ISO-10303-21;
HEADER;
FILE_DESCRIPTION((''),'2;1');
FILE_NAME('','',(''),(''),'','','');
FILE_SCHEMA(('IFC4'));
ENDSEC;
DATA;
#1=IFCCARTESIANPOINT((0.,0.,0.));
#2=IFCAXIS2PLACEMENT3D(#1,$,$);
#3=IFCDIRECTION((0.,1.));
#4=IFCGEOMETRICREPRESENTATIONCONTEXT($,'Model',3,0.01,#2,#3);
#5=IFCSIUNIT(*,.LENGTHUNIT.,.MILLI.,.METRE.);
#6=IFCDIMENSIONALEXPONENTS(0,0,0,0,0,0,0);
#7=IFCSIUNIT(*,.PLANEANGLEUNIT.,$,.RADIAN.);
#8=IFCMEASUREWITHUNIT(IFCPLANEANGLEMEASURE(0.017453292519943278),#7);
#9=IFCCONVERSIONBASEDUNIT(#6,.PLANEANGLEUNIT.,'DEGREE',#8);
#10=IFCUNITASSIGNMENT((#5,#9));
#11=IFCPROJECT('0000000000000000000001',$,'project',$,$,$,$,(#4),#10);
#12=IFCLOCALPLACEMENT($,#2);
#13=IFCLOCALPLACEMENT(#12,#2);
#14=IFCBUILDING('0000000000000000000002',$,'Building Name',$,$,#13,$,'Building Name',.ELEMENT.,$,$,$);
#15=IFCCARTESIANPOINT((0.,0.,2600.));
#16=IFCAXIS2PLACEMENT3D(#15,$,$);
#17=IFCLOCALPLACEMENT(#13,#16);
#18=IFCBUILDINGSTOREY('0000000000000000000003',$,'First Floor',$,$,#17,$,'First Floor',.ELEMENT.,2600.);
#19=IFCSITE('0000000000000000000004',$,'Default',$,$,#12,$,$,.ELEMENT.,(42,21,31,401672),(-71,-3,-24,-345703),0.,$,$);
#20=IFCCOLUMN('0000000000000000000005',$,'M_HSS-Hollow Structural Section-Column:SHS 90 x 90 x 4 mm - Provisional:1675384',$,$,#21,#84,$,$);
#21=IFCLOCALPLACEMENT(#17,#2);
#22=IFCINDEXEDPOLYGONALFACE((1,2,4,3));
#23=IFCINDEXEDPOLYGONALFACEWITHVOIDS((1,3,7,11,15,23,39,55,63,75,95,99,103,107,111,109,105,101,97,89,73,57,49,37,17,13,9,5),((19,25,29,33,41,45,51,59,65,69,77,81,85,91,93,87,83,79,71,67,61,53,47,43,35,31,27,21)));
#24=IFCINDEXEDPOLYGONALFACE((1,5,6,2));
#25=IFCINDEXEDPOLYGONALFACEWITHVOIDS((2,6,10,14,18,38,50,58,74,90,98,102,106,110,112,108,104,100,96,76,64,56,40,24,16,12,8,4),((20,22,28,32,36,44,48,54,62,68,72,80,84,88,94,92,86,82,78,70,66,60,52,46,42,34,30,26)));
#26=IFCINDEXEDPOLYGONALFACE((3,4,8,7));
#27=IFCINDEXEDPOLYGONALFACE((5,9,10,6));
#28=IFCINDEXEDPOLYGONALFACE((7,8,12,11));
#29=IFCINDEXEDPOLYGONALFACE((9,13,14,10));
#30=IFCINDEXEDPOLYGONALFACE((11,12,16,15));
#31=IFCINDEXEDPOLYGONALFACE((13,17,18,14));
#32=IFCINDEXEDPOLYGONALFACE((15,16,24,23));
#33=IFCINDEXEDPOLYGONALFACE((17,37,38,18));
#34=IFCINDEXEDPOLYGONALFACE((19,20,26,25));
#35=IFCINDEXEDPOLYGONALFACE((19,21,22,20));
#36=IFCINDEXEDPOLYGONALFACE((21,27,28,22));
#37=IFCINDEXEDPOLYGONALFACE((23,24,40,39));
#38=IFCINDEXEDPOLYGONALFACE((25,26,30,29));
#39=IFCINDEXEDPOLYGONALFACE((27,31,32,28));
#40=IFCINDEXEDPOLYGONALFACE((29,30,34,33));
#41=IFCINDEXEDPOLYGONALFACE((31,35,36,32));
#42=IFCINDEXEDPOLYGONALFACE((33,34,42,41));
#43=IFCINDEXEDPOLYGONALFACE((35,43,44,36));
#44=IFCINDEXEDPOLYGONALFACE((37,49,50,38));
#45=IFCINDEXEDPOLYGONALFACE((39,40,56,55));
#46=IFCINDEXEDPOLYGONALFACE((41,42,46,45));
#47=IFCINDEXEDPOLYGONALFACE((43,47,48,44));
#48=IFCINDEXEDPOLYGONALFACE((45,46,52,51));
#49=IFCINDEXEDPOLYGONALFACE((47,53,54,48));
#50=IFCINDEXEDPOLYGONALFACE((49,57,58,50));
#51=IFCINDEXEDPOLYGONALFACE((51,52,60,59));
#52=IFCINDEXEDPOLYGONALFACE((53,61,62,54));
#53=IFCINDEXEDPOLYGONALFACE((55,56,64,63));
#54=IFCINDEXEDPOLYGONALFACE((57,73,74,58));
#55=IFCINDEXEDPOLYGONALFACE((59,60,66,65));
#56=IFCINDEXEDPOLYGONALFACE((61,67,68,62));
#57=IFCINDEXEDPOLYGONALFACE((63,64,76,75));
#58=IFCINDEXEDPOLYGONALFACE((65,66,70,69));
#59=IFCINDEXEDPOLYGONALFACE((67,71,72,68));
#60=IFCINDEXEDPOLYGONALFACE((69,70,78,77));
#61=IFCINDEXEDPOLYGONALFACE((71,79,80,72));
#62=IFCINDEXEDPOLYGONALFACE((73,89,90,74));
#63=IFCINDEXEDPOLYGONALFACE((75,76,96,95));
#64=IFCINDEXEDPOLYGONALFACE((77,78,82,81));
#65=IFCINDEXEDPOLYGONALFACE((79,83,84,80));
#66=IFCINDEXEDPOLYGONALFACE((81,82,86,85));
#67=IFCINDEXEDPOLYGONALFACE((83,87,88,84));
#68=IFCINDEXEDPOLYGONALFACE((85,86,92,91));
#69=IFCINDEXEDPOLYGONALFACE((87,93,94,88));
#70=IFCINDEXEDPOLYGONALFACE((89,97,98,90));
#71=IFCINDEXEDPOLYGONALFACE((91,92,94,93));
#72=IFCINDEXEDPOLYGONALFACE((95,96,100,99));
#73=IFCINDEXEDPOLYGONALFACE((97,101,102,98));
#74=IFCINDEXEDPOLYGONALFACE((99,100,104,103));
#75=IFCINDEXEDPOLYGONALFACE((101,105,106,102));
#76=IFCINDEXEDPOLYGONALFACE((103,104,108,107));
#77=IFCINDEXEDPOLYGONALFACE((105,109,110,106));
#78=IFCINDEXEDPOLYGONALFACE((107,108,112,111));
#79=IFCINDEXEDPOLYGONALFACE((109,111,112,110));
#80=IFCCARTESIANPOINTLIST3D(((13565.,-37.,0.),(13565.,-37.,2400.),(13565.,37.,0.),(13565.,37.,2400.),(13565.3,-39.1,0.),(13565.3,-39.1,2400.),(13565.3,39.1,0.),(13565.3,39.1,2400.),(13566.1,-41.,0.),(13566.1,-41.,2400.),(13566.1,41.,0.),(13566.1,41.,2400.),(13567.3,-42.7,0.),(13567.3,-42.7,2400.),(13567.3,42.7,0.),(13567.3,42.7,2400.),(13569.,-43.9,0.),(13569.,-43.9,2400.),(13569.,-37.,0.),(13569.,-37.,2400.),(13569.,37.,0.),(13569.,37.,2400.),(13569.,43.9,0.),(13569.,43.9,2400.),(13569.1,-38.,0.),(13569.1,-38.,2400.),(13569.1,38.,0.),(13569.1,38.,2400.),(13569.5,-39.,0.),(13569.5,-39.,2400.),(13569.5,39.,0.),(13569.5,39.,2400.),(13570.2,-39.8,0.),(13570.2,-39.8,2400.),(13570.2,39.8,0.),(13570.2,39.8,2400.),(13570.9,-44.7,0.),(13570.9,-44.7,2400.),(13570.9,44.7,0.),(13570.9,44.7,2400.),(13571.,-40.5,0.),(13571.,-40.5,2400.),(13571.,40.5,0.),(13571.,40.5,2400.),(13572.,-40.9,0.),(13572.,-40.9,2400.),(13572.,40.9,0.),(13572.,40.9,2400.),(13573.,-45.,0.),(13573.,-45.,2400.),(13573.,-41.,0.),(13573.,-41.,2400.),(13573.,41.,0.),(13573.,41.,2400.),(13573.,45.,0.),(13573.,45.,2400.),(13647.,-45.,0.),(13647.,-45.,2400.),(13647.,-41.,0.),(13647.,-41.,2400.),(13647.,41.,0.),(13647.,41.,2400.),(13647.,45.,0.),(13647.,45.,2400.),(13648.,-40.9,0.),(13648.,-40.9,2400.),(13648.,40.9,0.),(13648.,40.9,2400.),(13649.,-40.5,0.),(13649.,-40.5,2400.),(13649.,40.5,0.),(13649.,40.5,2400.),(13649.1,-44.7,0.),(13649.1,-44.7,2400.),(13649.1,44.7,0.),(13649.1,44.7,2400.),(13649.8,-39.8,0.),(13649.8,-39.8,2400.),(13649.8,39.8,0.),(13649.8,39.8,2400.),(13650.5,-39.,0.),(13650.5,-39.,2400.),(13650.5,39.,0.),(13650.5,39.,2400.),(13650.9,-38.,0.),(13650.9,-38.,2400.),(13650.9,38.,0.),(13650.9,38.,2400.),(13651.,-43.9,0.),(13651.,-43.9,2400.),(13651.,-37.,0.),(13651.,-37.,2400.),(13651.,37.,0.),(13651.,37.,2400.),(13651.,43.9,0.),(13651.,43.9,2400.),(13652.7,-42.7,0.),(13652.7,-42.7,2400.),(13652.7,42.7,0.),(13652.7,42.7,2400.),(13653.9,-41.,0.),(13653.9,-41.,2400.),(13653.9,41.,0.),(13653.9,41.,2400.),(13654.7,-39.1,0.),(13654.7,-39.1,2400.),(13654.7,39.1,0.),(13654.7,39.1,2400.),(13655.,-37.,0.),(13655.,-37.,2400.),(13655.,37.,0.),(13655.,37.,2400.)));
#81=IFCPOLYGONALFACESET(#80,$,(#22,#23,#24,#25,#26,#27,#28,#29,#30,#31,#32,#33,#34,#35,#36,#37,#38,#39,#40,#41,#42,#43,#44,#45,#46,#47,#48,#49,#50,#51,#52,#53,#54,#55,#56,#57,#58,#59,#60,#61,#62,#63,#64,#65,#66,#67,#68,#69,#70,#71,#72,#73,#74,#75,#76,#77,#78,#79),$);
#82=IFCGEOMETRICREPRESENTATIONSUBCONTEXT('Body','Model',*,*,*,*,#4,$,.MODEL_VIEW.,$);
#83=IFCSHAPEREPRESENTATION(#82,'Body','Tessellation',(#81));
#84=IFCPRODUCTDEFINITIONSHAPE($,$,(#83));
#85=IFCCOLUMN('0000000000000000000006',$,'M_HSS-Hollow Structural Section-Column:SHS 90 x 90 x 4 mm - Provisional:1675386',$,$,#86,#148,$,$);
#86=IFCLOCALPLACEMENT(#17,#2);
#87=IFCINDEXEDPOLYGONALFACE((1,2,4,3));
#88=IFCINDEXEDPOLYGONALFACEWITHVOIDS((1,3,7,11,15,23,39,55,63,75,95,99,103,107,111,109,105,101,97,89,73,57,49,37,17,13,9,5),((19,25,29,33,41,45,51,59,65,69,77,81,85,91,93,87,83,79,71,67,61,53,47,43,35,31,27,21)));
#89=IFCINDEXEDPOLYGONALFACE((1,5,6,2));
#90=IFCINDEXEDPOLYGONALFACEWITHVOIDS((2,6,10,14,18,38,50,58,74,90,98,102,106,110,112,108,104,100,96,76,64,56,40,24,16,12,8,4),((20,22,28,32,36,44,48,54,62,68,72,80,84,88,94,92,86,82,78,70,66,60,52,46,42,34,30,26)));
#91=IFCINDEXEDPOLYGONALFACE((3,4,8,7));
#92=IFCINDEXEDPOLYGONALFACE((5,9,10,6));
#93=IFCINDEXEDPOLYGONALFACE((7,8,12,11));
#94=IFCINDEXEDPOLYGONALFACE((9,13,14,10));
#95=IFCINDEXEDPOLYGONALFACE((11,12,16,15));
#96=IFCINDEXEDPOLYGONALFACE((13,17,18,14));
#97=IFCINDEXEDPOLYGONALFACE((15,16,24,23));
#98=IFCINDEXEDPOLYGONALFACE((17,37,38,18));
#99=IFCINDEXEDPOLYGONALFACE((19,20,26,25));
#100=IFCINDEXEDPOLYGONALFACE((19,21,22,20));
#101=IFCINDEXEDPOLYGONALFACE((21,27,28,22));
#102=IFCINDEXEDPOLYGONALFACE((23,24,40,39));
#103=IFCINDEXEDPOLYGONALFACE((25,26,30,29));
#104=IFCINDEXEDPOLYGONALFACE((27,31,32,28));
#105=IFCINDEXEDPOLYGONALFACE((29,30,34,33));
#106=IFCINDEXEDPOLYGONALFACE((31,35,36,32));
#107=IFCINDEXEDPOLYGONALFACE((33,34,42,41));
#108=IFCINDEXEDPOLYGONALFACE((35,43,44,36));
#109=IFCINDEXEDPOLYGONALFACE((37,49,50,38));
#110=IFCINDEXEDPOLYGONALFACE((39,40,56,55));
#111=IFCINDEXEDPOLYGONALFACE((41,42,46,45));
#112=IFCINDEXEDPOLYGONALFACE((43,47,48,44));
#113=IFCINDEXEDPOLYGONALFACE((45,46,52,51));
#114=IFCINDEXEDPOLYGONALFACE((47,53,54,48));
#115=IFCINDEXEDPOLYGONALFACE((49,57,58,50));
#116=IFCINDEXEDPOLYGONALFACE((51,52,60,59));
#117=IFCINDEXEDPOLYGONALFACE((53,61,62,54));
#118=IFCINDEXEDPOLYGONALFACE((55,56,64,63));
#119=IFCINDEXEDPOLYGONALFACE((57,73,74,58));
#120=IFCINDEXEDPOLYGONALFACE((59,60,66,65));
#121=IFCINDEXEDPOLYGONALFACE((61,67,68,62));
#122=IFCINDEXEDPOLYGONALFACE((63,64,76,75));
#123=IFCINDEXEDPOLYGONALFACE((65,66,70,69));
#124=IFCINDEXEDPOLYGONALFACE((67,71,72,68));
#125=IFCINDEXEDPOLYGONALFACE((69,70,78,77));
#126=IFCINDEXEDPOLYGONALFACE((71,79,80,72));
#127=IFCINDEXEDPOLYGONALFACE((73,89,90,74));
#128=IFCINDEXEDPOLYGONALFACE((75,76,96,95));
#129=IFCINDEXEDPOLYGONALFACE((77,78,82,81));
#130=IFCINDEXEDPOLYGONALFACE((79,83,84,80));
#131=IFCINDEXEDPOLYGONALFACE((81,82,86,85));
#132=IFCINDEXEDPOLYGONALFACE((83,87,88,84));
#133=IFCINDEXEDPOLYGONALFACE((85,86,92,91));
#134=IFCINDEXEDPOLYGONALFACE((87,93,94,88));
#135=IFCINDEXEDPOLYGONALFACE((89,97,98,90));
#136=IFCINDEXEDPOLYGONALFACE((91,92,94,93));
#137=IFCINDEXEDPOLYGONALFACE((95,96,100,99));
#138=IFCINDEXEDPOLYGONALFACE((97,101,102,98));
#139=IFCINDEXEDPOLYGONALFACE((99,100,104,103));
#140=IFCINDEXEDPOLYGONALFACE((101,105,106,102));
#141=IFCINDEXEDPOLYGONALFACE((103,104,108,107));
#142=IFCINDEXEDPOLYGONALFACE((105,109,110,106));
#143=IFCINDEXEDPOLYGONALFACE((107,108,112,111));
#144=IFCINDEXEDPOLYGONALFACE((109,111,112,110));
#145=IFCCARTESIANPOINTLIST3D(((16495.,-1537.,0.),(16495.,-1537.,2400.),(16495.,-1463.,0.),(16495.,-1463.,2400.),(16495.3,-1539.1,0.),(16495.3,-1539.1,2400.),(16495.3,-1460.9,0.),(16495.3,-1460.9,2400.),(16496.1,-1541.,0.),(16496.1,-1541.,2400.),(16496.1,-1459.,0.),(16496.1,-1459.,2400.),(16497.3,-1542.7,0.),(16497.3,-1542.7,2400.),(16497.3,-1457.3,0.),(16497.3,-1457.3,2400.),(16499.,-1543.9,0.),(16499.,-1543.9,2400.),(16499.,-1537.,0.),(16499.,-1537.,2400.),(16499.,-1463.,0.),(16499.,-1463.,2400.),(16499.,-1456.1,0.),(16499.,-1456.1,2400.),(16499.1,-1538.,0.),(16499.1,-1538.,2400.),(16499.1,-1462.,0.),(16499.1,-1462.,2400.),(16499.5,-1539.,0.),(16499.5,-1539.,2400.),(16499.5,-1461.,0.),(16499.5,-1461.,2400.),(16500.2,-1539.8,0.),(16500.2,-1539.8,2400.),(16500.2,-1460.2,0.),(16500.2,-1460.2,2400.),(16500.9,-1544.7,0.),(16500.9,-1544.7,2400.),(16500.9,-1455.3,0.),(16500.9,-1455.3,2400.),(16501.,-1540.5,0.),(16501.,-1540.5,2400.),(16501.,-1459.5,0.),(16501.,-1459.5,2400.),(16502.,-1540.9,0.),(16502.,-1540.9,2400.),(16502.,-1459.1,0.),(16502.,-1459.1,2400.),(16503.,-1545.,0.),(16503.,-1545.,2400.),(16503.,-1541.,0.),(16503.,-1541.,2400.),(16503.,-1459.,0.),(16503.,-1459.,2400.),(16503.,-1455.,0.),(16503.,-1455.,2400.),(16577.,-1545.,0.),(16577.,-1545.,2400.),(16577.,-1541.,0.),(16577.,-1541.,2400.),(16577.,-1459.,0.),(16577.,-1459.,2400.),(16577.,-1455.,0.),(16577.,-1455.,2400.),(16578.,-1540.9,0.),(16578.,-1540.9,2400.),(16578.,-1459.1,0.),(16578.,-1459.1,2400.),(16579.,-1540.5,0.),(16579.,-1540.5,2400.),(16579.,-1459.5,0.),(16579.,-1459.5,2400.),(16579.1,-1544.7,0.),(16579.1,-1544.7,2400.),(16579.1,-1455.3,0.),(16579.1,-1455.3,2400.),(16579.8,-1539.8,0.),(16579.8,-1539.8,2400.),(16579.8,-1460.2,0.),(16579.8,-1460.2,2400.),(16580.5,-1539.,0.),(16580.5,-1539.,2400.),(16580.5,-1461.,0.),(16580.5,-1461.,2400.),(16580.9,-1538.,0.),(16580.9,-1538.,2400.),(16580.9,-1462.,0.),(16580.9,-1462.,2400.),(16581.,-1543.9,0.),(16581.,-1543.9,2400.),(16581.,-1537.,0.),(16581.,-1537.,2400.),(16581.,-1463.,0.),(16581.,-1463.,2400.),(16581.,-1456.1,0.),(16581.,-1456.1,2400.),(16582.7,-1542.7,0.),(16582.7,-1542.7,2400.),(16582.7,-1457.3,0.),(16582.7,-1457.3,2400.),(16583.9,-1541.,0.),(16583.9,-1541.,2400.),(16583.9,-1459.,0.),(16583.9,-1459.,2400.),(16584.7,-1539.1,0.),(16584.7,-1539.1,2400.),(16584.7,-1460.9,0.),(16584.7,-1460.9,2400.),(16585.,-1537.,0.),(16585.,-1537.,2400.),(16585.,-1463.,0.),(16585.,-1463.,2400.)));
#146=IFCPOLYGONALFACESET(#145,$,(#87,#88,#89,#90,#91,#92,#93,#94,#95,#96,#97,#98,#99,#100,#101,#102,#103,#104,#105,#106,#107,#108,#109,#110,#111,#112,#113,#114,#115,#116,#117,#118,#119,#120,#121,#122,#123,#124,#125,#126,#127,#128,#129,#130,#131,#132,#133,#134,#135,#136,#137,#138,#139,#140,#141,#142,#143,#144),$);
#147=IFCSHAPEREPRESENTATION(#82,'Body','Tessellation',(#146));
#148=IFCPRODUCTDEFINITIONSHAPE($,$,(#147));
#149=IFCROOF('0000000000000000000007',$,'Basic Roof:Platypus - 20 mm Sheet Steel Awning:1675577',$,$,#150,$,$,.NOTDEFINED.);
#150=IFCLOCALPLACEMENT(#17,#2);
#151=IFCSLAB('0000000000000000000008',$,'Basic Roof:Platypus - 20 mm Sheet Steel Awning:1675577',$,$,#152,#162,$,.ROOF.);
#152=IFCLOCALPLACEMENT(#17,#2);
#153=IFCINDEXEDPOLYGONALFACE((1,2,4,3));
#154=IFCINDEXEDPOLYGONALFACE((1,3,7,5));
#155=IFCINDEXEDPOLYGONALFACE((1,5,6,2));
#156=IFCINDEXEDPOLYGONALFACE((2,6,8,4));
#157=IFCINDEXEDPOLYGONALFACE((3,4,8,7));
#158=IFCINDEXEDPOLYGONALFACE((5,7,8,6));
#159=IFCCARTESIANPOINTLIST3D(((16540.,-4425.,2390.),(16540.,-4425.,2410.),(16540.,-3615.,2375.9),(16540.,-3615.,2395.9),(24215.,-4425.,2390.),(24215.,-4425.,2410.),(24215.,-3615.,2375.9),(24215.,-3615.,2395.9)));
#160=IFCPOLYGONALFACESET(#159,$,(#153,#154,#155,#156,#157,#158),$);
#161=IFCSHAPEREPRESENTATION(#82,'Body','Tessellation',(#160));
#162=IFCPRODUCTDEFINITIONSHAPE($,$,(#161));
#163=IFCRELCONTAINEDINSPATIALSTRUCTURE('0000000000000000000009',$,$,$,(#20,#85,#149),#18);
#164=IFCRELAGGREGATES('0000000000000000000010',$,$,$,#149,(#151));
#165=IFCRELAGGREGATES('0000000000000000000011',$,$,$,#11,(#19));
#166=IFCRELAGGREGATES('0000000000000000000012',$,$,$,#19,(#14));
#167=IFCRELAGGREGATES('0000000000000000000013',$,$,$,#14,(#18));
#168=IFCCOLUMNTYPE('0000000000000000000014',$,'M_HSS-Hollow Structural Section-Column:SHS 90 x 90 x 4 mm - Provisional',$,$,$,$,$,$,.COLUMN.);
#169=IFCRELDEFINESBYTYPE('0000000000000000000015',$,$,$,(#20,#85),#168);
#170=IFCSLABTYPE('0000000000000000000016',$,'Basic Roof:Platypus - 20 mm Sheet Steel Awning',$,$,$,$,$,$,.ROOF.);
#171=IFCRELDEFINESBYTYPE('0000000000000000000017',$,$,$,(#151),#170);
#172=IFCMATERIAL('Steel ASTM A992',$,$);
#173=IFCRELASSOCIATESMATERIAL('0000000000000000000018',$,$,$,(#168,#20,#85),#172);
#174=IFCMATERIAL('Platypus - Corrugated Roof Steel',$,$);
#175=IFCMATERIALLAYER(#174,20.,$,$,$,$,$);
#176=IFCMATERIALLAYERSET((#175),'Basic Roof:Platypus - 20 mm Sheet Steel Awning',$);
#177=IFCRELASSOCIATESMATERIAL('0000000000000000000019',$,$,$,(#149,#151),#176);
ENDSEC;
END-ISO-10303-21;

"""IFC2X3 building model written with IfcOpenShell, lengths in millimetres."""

from ifc_helpers import new_model, entity, si_unit, converted_unit, direction, frame, frame_2d, origin, place, context, subcontext, project, spatial, polyline, circle_curve, parameter, trimmed, segment, composite_curve, rectangle, outline, extrude, source, transform, mapped, material, layer, layer_set, type_object, type_shapes, element, aggregate, save


model = new_model("IFC2X3")

# Units and contexts
model_context = context("Model", 3, precision=0.01, world=origin(), true_north=direction((0.0, 1.0)))
body_context = subcontext(model_context, "Body", "Model", "MODEL_VIEW")
ifc_project = project(units=[si_unit("LENGTHUNIT", "METRE", prefix="MILLI"), converted_unit("PLANEANGLEUNIT", "DEGREE", entity("IfcPlaneAngleMeasure", 0.017453292519943278), si_unit("PLANEANGLEUNIT", "RADIAN"), dimensions=[0, 0, 0, 0, 0, 0, 0])], contexts=[model_context])

# Site, building, storey
site_placement = place(None, origin())
site = spatial("IfcSite", under=ifc_project, at=site_placement, Name="Default", CompositionType="ELEMENT", RefLatitude=(42, 21, 31, 401672), RefLongitude=(-71, -3, -24, -345703), RefElevation=0.0)
building_placement = place(site_placement, origin())
building = spatial("IfcBuilding", under=site, at=building_placement, Name="Building Name", LongName="Building Name", CompositionType="ELEMENT")
storey_placement = place(building_placement, frame((0.0, 0.0, 2600.0)))
storey = spatial("IfcBuildingStorey", under=building, at=storey_placement, Name="First Floor", LongName="First Floor", CompositionType="ELEMENT", Elevation=2600.0)

# Columns
ifc_material_1 = material(Name="Steel ASTM A992")
column_type = type_object("IfcColumnType", Name="M_HSS-Hollow Structural Section-Column:SHS 90 x 90 x 4 mm - Provisional", PredefinedType="COLUMN", material=ifc_material_1)
shared_shape_1 = source(origin(), body_context, "Body", "SweptSolid", [
    extrude(outline(composite_curve([segment(polyline([(-37.0, -45.0), (37.0, -45.0)]), True, "CONTINUOUS"), segment(trimmed(circle_curve(frame_2d((37.0, -37.0), x_axis=(-1.0, 0.0)), 8.0), [parameter(90.0)], [parameter(180.0)], True, "PARAMETER"), True, "CONTINUOUS"), segment(polyline([(45.0, -37.0), (45.0, 37.0)]), True, "CONTINUOUS"), segment(trimmed(circle_curve(frame_2d((37.0, 37.0), x_axis=(-1.0, 0.0)), 8.0), [parameter(180.0)], [parameter(270.0)], True, "PARAMETER"), True, "CONTINUOUS"), segment(polyline([(37.0, 45.0), (-37.0, 45.0)]), True, "CONTINUOUS"), segment(trimmed(circle_curve(frame_2d((-37.0, 37.0), x_axis=(-1.0, 0.0)), 8.0), [parameter(270.0)], [parameter(360.0)], True, "PARAMETER"), True, "CONTINUOUS"), segment(polyline([(-45.0, 37.0), (-45.0, -37.0)]), True, "CONTINUOUS"), segment(trimmed(circle_curve(frame_2d((-37.0, -37.0), x_axis=(-1.0, 0.0)), 8.0), [parameter(360.0)], [parameter(90.0)], True, "PARAMETER"), True, "CONTINUOUS")], self_intersect=False), holes=[composite_curve([segment(trimmed(circle_curve(frame_2d((-37.0, -37.0), x_axis=(-1.0, 0.0)), 4.0), [parameter(0.0)], [parameter(90.0)], True, "PARAMETER"), False, "CONTINUOUS"), segment(polyline([(-41.0, -37.0), (-41.0, 37.0)]), True, "CONTINUOUS"), segment(trimmed(circle_curve(frame_2d((-37.0, 37.0), x_axis=(-1.0, 0.0)), 4.0), [parameter(270.0)], [parameter(0.0)], True, "PARAMETER"), False, "CONTINUOUS"), segment(polyline([(-37.0, 41.0), (37.0, 41.0)]), True, "CONTINUOUS"), segment(trimmed(circle_curve(frame_2d((37.0, 37.0), x_axis=(-1.0, 0.0)), 4.0), [parameter(180.0)], [parameter(270.0)], True, "PARAMETER"), False, "CONTINUOUS"), segment(polyline([(41.0, 37.0), (41.0, -37.0)]), True, "CONTINUOUS"), segment(trimmed(circle_curve(frame_2d((37.0, -37.0), x_axis=(-1.0, 0.0)), 4.0), [parameter(90.0)], [parameter(180.0)], True, "PARAMETER"), False, "CONTINUOUS"), segment(polyline([(37.0, -41.0), (-37.0, -41.0)]), True, "CONTINUOUS")], self_intersect=False)]), frame((0.0, 0.0, 2600.0), z_axis=(0.0, 0.0, 1.0), x_axis=(-1.0, 0.0, 0.0)), (0.0, 0.0, 1.0), 2400.0),
])
type_shapes(column_type, [shared_shape_1])
for number, where, name in (
    (1, (13610.0, 0.0, -2600.0), "M_HSS-Hollow Structural Section-Column:SHS 90 x 90 x 4 mm - Provisional:1675384"),
    (2, (16540.0, -1500.0, -2600.0), "M_HSS-Hollow Structural Section-Column:SHS 90 x 90 x 4 mm - Provisional:1675386"),
):
    element("IfcColumn", number, at=place(storey_placement, frame(where)), inside=storey, type_object=column_type, material=ifc_material_1, Name=name, context=body_context, shape_type="MappedRepresentation", body=[
        mapped(shared_shape_1, transform((0.0, 0.0, 0.0), scale=1.0)),
    ])

# Roof, slab
ifc_material_2 = material(Name="Platypus - Corrugated Roof Steel")
ifc_layer_1 = layer(ifc_material_2, 20.0)
ifc_layer_set_1 = layer_set([ifc_layer_1], Name="Basic Roof:Platypus - 20 mm Sheet Steel Awning")
roof_placement = place(storey_placement, frame((16540.0, -4425.0, 2375.9)))
roof = element("IfcRoof", 3, at=roof_placement, inside=storey, material=ifc_layer_set_1, Name="Basic Roof:Platypus - 20 mm Sheet Steel Awning:1675577", ShapeType="NOTDEFINED")
slab_type = type_object("IfcSlabType", Name="Basic Roof:Platypus - 20 mm Sheet Steel Awning", PredefinedType="ROOF")
slab_placement = place(roof_placement, origin())
slab = element("IfcSlab", 4, at=slab_placement, type_object=slab_type, material=ifc_layer_set_1, Name="Basic Roof:Platypus - 20 mm Sheet Steel Awning:1675577", PredefinedType="ROOF", context=body_context, shape_type="SweptSolid", body=[
    extrude(rectangle(XDim=810.1, YDim=7675.0, at=frame_2d((0.0, 0.0), x_axis=(0.0, 1.0))), frame((3837.5, 405.0, 7.1), z_axis=(0.0, 0.017451, 0.999848), x_axis=(1.0, 0.0, 0.0)), (0.0, -0.017451, 0.999848), 20.0),
])
aggregate(roof, [slab])

save(model, "model.ifc")
